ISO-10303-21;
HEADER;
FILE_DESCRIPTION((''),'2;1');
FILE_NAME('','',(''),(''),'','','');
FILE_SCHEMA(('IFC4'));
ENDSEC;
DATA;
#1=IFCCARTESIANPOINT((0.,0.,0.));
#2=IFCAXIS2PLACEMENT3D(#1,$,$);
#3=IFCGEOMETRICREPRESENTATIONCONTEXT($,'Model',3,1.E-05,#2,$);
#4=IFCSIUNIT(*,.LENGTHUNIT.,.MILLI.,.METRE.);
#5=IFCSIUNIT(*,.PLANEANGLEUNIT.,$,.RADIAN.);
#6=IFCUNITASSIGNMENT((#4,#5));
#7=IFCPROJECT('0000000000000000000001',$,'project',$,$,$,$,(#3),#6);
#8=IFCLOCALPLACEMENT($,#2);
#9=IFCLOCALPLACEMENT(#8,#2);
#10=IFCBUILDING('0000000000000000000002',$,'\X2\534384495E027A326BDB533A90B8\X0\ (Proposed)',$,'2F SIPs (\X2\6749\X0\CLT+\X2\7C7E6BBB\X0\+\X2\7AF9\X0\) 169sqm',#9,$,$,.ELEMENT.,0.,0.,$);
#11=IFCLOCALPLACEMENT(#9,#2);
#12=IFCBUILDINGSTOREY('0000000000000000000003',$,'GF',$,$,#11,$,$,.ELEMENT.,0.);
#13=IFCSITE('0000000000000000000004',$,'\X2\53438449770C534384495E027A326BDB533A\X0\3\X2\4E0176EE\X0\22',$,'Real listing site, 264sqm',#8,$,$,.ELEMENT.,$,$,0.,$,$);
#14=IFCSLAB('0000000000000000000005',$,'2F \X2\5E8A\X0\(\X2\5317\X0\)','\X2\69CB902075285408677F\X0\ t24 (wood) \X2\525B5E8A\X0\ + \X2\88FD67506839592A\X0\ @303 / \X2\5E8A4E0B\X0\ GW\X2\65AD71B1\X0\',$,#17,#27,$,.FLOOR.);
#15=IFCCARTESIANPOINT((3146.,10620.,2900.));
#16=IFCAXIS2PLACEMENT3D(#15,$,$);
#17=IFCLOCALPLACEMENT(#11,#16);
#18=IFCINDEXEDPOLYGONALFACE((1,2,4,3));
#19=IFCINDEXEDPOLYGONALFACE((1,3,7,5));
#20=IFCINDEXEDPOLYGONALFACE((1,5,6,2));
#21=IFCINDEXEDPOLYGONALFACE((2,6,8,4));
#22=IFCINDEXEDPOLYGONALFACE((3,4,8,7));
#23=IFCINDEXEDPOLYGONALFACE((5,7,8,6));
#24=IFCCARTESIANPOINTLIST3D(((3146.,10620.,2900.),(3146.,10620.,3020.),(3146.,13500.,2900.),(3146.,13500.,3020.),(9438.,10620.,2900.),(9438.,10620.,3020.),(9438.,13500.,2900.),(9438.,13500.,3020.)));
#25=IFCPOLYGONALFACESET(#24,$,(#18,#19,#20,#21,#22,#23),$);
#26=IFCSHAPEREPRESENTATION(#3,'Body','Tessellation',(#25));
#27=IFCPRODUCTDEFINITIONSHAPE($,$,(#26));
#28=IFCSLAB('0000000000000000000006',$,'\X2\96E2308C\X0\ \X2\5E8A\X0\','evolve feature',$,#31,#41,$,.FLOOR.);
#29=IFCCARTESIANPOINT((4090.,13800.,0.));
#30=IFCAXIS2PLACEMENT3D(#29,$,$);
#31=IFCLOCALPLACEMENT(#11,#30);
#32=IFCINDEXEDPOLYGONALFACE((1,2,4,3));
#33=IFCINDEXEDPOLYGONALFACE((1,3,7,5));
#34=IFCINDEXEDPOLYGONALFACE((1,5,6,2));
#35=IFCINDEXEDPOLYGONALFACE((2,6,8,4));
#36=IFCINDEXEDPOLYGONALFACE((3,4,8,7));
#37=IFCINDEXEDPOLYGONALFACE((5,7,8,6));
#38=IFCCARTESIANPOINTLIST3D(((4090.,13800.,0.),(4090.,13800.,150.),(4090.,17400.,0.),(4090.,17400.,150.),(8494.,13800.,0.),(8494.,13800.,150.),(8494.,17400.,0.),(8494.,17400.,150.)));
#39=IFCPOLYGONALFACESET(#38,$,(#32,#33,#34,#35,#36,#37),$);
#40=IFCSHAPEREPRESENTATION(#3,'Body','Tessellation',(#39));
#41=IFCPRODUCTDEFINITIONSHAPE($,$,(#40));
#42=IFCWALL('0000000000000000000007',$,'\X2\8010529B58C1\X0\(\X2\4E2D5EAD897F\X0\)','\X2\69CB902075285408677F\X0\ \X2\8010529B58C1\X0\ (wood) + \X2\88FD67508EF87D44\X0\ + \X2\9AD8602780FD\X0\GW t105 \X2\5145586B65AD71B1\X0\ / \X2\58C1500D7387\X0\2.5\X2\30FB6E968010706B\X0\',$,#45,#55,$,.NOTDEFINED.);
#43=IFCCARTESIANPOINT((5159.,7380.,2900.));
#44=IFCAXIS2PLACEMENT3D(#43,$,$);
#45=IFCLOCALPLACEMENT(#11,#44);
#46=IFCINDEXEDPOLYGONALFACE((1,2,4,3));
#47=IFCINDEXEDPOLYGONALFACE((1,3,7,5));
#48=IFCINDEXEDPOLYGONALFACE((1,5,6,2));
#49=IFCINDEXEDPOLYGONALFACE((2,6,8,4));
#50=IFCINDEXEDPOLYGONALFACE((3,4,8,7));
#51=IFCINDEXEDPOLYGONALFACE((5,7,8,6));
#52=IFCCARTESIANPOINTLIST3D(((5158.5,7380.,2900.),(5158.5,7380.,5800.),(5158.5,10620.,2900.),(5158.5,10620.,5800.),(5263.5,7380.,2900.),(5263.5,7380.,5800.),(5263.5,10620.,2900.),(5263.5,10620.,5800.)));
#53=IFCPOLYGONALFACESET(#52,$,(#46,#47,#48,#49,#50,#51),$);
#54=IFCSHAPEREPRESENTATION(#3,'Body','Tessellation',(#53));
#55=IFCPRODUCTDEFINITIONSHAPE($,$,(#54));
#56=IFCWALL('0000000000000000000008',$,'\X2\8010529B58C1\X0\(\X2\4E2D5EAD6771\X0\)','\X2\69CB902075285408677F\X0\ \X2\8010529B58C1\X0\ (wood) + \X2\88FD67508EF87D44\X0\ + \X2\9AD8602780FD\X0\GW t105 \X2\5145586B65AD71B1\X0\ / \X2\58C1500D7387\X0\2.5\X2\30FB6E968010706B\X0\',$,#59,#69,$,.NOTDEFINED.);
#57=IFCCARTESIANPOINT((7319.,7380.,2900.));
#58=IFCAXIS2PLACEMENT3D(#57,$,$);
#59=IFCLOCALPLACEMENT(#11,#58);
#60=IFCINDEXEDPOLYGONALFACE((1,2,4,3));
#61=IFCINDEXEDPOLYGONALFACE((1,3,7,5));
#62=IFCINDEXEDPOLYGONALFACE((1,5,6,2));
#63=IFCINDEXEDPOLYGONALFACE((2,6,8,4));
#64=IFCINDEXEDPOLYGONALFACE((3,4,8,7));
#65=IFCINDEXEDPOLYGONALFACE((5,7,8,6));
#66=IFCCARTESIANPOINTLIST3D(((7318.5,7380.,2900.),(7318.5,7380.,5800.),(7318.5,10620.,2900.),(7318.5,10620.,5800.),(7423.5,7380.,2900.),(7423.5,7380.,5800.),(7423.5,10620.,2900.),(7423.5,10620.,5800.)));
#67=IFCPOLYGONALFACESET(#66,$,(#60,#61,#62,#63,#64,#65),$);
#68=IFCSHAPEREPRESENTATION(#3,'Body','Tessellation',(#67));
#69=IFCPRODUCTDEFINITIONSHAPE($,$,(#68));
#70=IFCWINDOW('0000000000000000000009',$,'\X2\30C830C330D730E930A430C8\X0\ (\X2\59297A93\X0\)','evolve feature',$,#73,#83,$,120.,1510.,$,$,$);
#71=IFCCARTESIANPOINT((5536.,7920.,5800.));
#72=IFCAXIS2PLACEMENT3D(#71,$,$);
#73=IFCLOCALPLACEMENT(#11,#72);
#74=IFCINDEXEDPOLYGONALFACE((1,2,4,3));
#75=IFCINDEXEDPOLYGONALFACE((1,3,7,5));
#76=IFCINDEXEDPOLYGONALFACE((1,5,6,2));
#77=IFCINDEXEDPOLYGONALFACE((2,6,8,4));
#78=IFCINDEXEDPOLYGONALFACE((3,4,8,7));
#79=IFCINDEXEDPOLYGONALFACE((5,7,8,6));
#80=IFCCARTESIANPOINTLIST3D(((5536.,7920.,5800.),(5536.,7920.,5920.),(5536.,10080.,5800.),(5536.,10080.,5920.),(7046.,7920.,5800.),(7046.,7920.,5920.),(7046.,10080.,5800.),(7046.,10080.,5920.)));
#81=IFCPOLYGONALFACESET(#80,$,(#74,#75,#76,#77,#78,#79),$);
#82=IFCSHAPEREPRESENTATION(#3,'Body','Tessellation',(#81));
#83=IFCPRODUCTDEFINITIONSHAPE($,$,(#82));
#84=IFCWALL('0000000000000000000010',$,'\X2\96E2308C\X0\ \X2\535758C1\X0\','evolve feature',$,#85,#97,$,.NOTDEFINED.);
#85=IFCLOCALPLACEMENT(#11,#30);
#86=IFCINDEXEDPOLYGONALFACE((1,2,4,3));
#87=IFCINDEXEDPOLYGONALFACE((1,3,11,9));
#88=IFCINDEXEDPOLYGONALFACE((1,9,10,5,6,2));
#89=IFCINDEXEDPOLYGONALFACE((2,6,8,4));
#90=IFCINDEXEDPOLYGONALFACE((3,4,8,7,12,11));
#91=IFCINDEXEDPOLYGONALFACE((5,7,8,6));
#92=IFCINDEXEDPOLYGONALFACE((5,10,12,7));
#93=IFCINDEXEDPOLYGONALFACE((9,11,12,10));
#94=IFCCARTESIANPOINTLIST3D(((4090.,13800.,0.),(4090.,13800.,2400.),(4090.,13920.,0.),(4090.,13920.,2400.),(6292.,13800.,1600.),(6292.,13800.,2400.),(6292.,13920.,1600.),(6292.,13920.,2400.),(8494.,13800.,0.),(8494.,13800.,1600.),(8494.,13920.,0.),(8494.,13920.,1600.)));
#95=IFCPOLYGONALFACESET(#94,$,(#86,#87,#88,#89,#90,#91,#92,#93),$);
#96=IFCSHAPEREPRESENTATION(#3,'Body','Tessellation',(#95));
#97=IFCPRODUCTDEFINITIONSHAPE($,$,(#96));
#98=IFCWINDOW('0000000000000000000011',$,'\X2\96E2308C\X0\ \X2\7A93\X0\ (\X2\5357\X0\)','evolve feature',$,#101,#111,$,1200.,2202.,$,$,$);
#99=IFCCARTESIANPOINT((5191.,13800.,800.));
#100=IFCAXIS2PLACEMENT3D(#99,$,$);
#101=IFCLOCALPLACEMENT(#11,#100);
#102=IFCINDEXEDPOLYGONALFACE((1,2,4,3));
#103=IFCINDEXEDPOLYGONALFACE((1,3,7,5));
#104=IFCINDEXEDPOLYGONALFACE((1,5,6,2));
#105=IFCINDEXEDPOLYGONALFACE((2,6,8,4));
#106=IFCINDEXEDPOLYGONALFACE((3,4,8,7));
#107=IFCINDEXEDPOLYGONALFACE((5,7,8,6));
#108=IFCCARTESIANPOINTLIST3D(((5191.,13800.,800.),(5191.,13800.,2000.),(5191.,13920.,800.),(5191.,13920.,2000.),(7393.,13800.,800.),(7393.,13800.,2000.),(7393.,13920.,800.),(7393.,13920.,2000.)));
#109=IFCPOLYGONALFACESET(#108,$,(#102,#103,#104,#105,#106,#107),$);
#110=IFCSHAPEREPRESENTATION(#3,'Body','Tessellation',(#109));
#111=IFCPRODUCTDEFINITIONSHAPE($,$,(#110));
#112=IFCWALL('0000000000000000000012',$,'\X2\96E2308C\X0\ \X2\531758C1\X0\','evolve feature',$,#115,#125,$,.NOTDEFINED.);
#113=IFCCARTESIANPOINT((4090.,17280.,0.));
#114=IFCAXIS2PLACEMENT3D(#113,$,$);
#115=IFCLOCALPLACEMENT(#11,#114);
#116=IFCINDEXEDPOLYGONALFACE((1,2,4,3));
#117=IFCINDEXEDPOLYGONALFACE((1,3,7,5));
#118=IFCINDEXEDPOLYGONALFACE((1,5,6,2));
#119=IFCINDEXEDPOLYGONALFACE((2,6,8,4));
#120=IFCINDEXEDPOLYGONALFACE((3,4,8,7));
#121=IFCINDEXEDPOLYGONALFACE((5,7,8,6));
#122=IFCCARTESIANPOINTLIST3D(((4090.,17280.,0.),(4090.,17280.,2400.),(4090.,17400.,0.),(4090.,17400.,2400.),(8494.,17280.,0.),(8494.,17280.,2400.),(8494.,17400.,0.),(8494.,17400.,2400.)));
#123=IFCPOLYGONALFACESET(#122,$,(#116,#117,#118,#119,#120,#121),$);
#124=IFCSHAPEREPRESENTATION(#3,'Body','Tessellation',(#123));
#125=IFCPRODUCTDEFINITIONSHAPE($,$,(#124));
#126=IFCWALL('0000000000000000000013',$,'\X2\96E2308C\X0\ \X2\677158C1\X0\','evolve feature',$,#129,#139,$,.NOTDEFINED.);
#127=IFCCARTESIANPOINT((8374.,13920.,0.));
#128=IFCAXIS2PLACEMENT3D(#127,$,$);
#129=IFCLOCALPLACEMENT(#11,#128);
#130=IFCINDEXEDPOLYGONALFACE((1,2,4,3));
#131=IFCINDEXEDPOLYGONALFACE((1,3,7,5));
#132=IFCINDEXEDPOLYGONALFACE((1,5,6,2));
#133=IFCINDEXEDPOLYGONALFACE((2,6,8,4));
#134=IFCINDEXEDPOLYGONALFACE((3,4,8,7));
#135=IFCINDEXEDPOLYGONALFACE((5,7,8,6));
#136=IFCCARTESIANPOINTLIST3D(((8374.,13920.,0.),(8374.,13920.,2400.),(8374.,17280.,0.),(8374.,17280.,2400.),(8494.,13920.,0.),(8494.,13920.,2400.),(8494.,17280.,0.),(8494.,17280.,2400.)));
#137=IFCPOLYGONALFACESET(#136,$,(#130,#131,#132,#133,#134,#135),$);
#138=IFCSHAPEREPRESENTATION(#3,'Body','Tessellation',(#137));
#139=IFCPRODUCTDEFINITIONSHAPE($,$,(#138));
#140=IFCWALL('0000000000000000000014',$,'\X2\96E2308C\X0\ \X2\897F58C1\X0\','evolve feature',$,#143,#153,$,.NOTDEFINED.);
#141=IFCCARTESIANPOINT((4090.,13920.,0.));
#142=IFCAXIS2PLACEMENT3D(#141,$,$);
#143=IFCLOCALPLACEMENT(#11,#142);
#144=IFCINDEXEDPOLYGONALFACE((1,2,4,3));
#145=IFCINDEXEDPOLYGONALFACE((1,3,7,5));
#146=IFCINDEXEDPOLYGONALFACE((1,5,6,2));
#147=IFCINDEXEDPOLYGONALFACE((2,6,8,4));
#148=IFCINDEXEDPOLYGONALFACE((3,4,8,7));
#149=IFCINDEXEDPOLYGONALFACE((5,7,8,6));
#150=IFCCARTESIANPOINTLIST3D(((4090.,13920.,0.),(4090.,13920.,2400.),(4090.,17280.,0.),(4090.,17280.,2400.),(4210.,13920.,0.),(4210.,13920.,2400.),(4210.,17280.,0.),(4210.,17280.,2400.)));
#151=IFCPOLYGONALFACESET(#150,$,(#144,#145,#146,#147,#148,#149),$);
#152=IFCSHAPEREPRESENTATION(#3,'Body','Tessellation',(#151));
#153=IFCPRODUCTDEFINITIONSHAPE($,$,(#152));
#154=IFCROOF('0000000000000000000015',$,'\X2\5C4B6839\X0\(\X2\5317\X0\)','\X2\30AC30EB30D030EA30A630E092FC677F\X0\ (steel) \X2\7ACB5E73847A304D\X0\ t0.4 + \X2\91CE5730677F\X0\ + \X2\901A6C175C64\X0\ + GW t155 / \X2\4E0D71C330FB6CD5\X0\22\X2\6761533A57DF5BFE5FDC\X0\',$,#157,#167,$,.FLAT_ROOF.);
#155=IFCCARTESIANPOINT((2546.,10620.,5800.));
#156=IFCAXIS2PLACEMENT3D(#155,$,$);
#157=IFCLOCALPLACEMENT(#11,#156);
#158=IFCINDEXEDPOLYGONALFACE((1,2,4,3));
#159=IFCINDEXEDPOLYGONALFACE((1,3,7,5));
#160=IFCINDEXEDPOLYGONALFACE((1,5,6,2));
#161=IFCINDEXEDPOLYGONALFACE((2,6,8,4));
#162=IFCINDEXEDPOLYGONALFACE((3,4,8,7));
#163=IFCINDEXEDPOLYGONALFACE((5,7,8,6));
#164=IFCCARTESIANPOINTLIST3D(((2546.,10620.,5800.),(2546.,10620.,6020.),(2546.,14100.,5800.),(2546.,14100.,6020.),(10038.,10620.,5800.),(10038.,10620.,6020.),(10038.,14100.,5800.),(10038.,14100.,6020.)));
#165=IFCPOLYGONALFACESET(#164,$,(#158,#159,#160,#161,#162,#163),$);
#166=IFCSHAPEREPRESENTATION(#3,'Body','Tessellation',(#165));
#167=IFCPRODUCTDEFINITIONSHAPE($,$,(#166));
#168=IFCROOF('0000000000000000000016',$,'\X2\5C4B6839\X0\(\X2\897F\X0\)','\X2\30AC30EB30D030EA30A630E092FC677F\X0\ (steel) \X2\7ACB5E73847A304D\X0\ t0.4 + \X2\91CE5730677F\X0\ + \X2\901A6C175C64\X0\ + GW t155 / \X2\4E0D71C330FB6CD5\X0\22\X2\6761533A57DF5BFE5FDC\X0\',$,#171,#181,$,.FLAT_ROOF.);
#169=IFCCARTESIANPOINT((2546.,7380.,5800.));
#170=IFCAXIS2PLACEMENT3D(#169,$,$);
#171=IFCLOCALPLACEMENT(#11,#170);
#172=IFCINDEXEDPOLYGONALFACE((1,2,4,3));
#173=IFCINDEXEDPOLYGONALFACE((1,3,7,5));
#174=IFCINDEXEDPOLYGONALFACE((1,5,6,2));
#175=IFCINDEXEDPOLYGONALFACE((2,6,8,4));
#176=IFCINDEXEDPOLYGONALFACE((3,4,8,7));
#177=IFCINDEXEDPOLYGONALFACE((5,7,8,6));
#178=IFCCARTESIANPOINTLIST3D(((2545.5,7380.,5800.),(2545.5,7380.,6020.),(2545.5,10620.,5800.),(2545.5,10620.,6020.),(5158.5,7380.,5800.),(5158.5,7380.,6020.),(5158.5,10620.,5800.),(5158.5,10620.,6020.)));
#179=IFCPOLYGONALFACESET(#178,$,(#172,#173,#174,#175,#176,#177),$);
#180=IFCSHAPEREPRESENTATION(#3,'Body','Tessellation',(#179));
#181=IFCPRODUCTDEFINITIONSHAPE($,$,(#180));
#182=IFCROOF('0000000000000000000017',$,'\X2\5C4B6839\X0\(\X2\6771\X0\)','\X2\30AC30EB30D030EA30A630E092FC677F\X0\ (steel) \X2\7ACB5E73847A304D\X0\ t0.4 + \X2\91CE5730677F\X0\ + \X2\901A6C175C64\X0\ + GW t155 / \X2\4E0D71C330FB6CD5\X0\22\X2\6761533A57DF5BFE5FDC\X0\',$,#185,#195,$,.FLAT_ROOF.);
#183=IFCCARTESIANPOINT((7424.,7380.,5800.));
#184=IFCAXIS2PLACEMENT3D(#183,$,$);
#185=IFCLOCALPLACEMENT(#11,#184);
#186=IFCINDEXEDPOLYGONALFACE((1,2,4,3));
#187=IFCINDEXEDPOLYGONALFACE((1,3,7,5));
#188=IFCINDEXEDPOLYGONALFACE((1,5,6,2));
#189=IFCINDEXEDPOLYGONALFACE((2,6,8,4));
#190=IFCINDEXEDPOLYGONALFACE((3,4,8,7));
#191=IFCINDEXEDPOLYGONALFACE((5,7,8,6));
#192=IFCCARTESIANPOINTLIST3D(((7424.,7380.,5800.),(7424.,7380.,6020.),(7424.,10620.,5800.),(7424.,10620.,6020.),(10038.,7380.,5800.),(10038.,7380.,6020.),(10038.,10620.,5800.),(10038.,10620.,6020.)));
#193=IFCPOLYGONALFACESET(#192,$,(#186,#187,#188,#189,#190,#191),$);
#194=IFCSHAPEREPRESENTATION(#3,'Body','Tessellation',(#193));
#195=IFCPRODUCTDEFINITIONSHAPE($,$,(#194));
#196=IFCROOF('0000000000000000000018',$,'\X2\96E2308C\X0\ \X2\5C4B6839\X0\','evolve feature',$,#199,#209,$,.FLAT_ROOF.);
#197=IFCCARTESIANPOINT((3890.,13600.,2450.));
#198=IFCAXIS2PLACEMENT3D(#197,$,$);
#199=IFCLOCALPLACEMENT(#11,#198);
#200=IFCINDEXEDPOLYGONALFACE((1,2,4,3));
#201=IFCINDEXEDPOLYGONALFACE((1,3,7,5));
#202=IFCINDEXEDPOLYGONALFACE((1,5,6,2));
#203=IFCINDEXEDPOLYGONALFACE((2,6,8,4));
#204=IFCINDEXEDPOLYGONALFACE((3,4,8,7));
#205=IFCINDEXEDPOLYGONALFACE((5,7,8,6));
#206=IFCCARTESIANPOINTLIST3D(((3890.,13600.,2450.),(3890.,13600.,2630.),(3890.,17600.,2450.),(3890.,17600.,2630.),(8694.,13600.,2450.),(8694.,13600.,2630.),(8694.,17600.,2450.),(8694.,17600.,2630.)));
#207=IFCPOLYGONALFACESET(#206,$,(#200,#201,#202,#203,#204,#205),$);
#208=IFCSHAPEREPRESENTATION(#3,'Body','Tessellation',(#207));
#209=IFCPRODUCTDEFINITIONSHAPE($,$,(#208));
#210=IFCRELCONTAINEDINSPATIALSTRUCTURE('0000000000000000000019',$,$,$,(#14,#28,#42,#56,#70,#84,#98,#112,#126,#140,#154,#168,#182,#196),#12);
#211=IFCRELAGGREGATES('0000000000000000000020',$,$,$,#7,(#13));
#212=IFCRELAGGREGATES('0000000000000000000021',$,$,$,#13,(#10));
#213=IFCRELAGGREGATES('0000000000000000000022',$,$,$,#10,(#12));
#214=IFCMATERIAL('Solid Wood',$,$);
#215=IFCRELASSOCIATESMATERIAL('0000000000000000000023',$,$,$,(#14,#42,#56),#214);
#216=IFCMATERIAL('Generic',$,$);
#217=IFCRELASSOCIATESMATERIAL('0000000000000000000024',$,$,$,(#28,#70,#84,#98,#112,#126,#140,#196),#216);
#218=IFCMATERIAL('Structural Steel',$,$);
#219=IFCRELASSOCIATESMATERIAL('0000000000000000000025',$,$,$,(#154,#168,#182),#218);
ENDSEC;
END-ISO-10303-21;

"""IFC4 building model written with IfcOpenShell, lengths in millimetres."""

from ifc_helpers import new_model, si_unit, frame, frame_2d, origin, place, context, project, spatial, rectangle, extrude, material, element, fill, save


model = new_model("IFC4")

# Units and contexts
model_context = context("Model", 3, precision=1e-05, world=origin())
ifc_project = project(units=[si_unit("LENGTHUNIT", "METRE", prefix="MILLI"), si_unit("PLANEANGLEUNIT", "RADIAN")], contexts=[model_context])

# Site, building, storey
site_placement = place(None, origin())
site = spatial("IfcSite", under=ifc_project, at=site_placement, Name="千葉県千葉市稲毛区3丁目22", ObjectType="Real listing site, 264sqm", CompositionType="ELEMENT", RefElevation=0.0)
building_placement = place(site_placement, origin())
building = spatial("IfcBuilding", under=site, at=building_placement, Name="千葉市稲毛区邸 (Proposed)", ObjectType="2F SIPs (杉CLT+籾殻+竹) 169sqm", CompositionType="ELEMENT", ElevationOfRefHeight=0.0, ElevationOfTerrain=0.0)
storey_placement = place(building_placement, origin())
storey = spatial("IfcBuildingStorey", under=building, at=storey_placement, Name="GF", CompositionType="ELEMENT", Elevation=0.0)

# Slabs
ifc_material_1 = material(Name="Solid Wood")
slab_1_placement = place(storey_placement, frame((3146.0, 10620.0, 2900.0)))
element("IfcSlab", 1, at=slab_1_placement, inside=storey, material=ifc_material_1, Name="2F 床(北)", Description="構造用合板 t24 (wood) 剛床 + 製材根太 @303 / 床下 GW断熱", PredefinedType="FLOOR", context=model_context, shape_type="SweptSolid", body=[
    extrude(rectangle(XDim=6292.0, YDim=2880.0, at=frame_2d((3146.0, 1440.0))), frame((3146.0, 10620.0, 2900.0)), (0.0, 0.0, 1.0), 120.0),
])
ifc_material_2 = material(Name="Generic")
slab_2_placement = place(storey_placement, frame((4090.0, 13800.0, 0.0)))
element("IfcSlab", 2, at=slab_2_placement, inside=storey, material=ifc_material_2, Name="離れ 床", Description="evolve feature", PredefinedType="FLOOR", context=model_context, shape_type="SweptSolid", body=[
    extrude(rectangle(XDim=4404.0, YDim=3600.0, at=frame_2d((2202.0, 1800.0))), frame((4090.0, 13800.0, 0.0)), (0.0, 0.0, 1.0), 150.0),
])

# Walls
wall_1_placement = place(storey_placement, frame((5159.0, 7380.0, 2900.0)))
element("IfcWall", 3, at=wall_1_placement, inside=storey, material=ifc_material_1, Name="耐力壁(中庭西)", Description="構造用合板 耐力壁 (wood) + 製材軸組 + 高性能GW t105 充填断熱 / 壁倍率2.5・準耐火", PredefinedType="NOTDEFINED", context=model_context, shape_type="SweptSolid", body=[
    extrude(rectangle(XDim=105.0, YDim=3240.0, at=frame_2d((52.0, 1620.0))), frame((5159.0, 7380.0, 2900.0)), (0.0, 0.0, 1.0), 2900.0),
])
wall_2_placement = place(storey_placement, frame((7319.0, 7380.0, 2900.0)))
element("IfcWall", 4, at=wall_2_placement, inside=storey, material=ifc_material_1, Name="耐力壁(中庭東)", Description="構造用合板 耐力壁 (wood) + 製材軸組 + 高性能GW t105 充填断熱 / 壁倍率2.5・準耐火", PredefinedType="NOTDEFINED", context=model_context, shape_type="SweptSolid", body=[
    extrude(rectangle(XDim=105.0, YDim=3240.0, at=frame_2d((52.0, 1620.0))), frame((7319.0, 7380.0, 2900.0)), (0.0, 0.0, 1.0), 2900.0),
])

# Window
window_1_placement = place(storey_placement, frame((5536.0, 7920.0, 5800.0)))
element("IfcWindow", 5, at=window_1_placement, inside=storey, material=ifc_material_2, Name="トップライト (天窓)", Description="evolve feature", OverallHeight=120.0, OverallWidth=1510.0, context=model_context, shape_type="SweptSolid", body=[
    extrude(rectangle(XDim=1510.0, YDim=2160.0, at=frame_2d((755.0, 1080.0))), frame((5536.0, 7920.0, 5800.0)), (0.0, 0.0, 1.0), 120.0),
])

# Wall, opening, window
wall_3_placement = place(storey_placement, frame((4090.0, 13800.0, 0.0)))
wall_3 = element("IfcWall", 6, at=wall_3_placement, inside=storey, material=ifc_material_2, Name="離れ 南壁", Description="evolve feature", PredefinedType="NOTDEFINED", context=model_context, shape_type="SweptSolid", body=[
    extrude(rectangle(XDim=4404.0, YDim=120.0, at=frame_2d((2202.0, 60.0))), frame((4090.0, 13800.0, 0.0)), (0.0, 0.0, 1.0), 2400.0),
])
opening_1_placement = place(storey_placement, frame((5191.0, 13800.0, 800.0)))
opening_1 = element("IfcOpeningElement", 7, at=opening_1_placement, cuts=wall_3, PredefinedType="NOTDEFINED", context=model_context, shape_type="SweptSolid", body=[
    extrude(rectangle(XDim=2202.0, YDim=120.0, at=frame_2d((1101.0, 60.0))), frame((5191.0, 13800.0, 800.0)), (0.0, 0.0, 1.0), 1200.0),
])
window_2_placement = place(storey_placement, frame((5191.0, 13800.0, 800.0)))
window_2 = element("IfcWindow", 8, at=window_2_placement, inside=storey, material=ifc_material_2, Name="離れ 窓 (南)", Description="evolve feature", OverallHeight=1200.0, OverallWidth=2202.0, context=model_context, shape_type="SweptSolid", body=[
    extrude(rectangle(XDim=2202.0, YDim=120.0, at=frame_2d((1101.0, 60.0))), frame((5191.0, 13800.0, 800.0)), (0.0, 0.0, 1.0), 1200.0),
])
fill(opening_1, window_2)

# Walls
wall_4_placement = place(storey_placement, frame((4090.0, 17280.0, 0.0)))
element("IfcWall", 9, at=wall_4_placement, inside=storey, material=ifc_material_2, Name="離れ 北壁", Description="evolve feature", PredefinedType="NOTDEFINED", context=model_context, shape_type="SweptSolid", body=[
    extrude(rectangle(XDim=4404.0, YDim=120.0, at=frame_2d((2202.0, 60.0))), frame((4090.0, 17280.0, 0.0)), (0.0, 0.0, 1.0), 2400.0),
])
wall_5_placement = place(storey_placement, frame((8374.0, 13920.0, 0.0)))
element("IfcWall", 10, at=wall_5_placement, inside=storey, material=ifc_material_2, Name="離れ 東壁", Description="evolve feature", PredefinedType="NOTDEFINED", context=model_context, shape_type="SweptSolid", body=[
    extrude(rectangle(XDim=120.0, YDim=3360.0, at=frame_2d((60.0, 1680.0))), frame((8374.0, 13920.0, 0.0)), (0.0, 0.0, 1.0), 2400.0),
])
wall_6_placement = place(storey_placement, frame((4090.0, 13920.0, 0.0)))
element("IfcWall", 11, at=wall_6_placement, inside=storey, material=ifc_material_2, Name="離れ 西壁", Description="evolve feature", PredefinedType="NOTDEFINED", context=model_context, shape_type="SweptSolid", body=[
    extrude(rectangle(XDim=120.0, YDim=3360.0, at=frame_2d((60.0, 1680.0))), frame((4090.0, 13920.0, 0.0)), (0.0, 0.0, 1.0), 2400.0),
])

# Roofs
ifc_material_3 = material(Name="Structural Steel")
for number, where, name in (
    (12, (2546.0, 10620.0, 5800.0), "屋根(北)"),
):
    element("IfcRoof", number, at=place(storey_placement, frame(where)), inside=storey, material=ifc_material_3, Name=name, Description="ガルバリウム鋼板 (steel) 立平葺き t0.4 + 野地板 + 通気層 + GW t155 / 不燃・法22条区域対応", PredefinedType="FLAT_ROOF", context=model_context, shape_type="SweptSolid", body=[
        extrude(rectangle(XDim=7492.0, YDim=3480.0, at=frame_2d((3746.0, 1740.0))), frame((2546.0, 10620.0, 5800.0)), (0.0, 0.0, 1.0), 220.0),
    ])
roof_1_placement = place(storey_placement, frame((2546.0, 7380.0, 5800.0)))
element("IfcRoof", 13, at=roof_1_placement, inside=storey, material=ifc_material_3, Name="屋根(西)", Description="ガルバリウム鋼板 (steel) 立平葺き t0.4 + 野地板 + 通気層 + GW t155 / 不燃・法22条区域対応", PredefinedType="FLAT_ROOF", context=model_context, shape_type="SweptSolid", body=[
    extrude(rectangle(XDim=2613.0, YDim=3240.0, at=frame_2d((1306.0, 1620.0))), frame((2546.0, 7380.0, 5800.0)), (0.0, 0.0, 1.0), 220.0),
])
roof_2_placement = place(storey_placement, frame((7424.0, 7380.0, 5800.0)))
element("IfcRoof", 14, at=roof_2_placement, inside=storey, material=ifc_material_3, Name="屋根(東)", Description="ガルバリウム鋼板 (steel) 立平葺き t0.4 + 野地板 + 通気層 + GW t155 / 不燃・法22条区域対応", PredefinedType="FLAT_ROOF", context=model_context, shape_type="SweptSolid", body=[
    extrude(rectangle(XDim=2614.0, YDim=3240.0, at=frame_2d((1307.0, 1620.0))), frame((7424.0, 7380.0, 5800.0)), (0.0, 0.0, 1.0), 220.0),
])
roof_3_placement = place(storey_placement, frame((3890.0, 13600.0, 2450.0)))
element("IfcRoof", 15, at=roof_3_placement, inside=storey, material=ifc_material_2, Name="離れ 屋根", Description="evolve feature", PredefinedType="FLAT_ROOF", context=model_context, shape_type="SweptSolid", body=[
    extrude(rectangle(XDim=4804.0, YDim=4000.0, at=frame_2d((2402.0, 2000.0))), frame((3890.0, 13600.0, 2450.0)), (0.0, 0.0, 1.0), 180.0),
])

save(model, "model.ifc")
